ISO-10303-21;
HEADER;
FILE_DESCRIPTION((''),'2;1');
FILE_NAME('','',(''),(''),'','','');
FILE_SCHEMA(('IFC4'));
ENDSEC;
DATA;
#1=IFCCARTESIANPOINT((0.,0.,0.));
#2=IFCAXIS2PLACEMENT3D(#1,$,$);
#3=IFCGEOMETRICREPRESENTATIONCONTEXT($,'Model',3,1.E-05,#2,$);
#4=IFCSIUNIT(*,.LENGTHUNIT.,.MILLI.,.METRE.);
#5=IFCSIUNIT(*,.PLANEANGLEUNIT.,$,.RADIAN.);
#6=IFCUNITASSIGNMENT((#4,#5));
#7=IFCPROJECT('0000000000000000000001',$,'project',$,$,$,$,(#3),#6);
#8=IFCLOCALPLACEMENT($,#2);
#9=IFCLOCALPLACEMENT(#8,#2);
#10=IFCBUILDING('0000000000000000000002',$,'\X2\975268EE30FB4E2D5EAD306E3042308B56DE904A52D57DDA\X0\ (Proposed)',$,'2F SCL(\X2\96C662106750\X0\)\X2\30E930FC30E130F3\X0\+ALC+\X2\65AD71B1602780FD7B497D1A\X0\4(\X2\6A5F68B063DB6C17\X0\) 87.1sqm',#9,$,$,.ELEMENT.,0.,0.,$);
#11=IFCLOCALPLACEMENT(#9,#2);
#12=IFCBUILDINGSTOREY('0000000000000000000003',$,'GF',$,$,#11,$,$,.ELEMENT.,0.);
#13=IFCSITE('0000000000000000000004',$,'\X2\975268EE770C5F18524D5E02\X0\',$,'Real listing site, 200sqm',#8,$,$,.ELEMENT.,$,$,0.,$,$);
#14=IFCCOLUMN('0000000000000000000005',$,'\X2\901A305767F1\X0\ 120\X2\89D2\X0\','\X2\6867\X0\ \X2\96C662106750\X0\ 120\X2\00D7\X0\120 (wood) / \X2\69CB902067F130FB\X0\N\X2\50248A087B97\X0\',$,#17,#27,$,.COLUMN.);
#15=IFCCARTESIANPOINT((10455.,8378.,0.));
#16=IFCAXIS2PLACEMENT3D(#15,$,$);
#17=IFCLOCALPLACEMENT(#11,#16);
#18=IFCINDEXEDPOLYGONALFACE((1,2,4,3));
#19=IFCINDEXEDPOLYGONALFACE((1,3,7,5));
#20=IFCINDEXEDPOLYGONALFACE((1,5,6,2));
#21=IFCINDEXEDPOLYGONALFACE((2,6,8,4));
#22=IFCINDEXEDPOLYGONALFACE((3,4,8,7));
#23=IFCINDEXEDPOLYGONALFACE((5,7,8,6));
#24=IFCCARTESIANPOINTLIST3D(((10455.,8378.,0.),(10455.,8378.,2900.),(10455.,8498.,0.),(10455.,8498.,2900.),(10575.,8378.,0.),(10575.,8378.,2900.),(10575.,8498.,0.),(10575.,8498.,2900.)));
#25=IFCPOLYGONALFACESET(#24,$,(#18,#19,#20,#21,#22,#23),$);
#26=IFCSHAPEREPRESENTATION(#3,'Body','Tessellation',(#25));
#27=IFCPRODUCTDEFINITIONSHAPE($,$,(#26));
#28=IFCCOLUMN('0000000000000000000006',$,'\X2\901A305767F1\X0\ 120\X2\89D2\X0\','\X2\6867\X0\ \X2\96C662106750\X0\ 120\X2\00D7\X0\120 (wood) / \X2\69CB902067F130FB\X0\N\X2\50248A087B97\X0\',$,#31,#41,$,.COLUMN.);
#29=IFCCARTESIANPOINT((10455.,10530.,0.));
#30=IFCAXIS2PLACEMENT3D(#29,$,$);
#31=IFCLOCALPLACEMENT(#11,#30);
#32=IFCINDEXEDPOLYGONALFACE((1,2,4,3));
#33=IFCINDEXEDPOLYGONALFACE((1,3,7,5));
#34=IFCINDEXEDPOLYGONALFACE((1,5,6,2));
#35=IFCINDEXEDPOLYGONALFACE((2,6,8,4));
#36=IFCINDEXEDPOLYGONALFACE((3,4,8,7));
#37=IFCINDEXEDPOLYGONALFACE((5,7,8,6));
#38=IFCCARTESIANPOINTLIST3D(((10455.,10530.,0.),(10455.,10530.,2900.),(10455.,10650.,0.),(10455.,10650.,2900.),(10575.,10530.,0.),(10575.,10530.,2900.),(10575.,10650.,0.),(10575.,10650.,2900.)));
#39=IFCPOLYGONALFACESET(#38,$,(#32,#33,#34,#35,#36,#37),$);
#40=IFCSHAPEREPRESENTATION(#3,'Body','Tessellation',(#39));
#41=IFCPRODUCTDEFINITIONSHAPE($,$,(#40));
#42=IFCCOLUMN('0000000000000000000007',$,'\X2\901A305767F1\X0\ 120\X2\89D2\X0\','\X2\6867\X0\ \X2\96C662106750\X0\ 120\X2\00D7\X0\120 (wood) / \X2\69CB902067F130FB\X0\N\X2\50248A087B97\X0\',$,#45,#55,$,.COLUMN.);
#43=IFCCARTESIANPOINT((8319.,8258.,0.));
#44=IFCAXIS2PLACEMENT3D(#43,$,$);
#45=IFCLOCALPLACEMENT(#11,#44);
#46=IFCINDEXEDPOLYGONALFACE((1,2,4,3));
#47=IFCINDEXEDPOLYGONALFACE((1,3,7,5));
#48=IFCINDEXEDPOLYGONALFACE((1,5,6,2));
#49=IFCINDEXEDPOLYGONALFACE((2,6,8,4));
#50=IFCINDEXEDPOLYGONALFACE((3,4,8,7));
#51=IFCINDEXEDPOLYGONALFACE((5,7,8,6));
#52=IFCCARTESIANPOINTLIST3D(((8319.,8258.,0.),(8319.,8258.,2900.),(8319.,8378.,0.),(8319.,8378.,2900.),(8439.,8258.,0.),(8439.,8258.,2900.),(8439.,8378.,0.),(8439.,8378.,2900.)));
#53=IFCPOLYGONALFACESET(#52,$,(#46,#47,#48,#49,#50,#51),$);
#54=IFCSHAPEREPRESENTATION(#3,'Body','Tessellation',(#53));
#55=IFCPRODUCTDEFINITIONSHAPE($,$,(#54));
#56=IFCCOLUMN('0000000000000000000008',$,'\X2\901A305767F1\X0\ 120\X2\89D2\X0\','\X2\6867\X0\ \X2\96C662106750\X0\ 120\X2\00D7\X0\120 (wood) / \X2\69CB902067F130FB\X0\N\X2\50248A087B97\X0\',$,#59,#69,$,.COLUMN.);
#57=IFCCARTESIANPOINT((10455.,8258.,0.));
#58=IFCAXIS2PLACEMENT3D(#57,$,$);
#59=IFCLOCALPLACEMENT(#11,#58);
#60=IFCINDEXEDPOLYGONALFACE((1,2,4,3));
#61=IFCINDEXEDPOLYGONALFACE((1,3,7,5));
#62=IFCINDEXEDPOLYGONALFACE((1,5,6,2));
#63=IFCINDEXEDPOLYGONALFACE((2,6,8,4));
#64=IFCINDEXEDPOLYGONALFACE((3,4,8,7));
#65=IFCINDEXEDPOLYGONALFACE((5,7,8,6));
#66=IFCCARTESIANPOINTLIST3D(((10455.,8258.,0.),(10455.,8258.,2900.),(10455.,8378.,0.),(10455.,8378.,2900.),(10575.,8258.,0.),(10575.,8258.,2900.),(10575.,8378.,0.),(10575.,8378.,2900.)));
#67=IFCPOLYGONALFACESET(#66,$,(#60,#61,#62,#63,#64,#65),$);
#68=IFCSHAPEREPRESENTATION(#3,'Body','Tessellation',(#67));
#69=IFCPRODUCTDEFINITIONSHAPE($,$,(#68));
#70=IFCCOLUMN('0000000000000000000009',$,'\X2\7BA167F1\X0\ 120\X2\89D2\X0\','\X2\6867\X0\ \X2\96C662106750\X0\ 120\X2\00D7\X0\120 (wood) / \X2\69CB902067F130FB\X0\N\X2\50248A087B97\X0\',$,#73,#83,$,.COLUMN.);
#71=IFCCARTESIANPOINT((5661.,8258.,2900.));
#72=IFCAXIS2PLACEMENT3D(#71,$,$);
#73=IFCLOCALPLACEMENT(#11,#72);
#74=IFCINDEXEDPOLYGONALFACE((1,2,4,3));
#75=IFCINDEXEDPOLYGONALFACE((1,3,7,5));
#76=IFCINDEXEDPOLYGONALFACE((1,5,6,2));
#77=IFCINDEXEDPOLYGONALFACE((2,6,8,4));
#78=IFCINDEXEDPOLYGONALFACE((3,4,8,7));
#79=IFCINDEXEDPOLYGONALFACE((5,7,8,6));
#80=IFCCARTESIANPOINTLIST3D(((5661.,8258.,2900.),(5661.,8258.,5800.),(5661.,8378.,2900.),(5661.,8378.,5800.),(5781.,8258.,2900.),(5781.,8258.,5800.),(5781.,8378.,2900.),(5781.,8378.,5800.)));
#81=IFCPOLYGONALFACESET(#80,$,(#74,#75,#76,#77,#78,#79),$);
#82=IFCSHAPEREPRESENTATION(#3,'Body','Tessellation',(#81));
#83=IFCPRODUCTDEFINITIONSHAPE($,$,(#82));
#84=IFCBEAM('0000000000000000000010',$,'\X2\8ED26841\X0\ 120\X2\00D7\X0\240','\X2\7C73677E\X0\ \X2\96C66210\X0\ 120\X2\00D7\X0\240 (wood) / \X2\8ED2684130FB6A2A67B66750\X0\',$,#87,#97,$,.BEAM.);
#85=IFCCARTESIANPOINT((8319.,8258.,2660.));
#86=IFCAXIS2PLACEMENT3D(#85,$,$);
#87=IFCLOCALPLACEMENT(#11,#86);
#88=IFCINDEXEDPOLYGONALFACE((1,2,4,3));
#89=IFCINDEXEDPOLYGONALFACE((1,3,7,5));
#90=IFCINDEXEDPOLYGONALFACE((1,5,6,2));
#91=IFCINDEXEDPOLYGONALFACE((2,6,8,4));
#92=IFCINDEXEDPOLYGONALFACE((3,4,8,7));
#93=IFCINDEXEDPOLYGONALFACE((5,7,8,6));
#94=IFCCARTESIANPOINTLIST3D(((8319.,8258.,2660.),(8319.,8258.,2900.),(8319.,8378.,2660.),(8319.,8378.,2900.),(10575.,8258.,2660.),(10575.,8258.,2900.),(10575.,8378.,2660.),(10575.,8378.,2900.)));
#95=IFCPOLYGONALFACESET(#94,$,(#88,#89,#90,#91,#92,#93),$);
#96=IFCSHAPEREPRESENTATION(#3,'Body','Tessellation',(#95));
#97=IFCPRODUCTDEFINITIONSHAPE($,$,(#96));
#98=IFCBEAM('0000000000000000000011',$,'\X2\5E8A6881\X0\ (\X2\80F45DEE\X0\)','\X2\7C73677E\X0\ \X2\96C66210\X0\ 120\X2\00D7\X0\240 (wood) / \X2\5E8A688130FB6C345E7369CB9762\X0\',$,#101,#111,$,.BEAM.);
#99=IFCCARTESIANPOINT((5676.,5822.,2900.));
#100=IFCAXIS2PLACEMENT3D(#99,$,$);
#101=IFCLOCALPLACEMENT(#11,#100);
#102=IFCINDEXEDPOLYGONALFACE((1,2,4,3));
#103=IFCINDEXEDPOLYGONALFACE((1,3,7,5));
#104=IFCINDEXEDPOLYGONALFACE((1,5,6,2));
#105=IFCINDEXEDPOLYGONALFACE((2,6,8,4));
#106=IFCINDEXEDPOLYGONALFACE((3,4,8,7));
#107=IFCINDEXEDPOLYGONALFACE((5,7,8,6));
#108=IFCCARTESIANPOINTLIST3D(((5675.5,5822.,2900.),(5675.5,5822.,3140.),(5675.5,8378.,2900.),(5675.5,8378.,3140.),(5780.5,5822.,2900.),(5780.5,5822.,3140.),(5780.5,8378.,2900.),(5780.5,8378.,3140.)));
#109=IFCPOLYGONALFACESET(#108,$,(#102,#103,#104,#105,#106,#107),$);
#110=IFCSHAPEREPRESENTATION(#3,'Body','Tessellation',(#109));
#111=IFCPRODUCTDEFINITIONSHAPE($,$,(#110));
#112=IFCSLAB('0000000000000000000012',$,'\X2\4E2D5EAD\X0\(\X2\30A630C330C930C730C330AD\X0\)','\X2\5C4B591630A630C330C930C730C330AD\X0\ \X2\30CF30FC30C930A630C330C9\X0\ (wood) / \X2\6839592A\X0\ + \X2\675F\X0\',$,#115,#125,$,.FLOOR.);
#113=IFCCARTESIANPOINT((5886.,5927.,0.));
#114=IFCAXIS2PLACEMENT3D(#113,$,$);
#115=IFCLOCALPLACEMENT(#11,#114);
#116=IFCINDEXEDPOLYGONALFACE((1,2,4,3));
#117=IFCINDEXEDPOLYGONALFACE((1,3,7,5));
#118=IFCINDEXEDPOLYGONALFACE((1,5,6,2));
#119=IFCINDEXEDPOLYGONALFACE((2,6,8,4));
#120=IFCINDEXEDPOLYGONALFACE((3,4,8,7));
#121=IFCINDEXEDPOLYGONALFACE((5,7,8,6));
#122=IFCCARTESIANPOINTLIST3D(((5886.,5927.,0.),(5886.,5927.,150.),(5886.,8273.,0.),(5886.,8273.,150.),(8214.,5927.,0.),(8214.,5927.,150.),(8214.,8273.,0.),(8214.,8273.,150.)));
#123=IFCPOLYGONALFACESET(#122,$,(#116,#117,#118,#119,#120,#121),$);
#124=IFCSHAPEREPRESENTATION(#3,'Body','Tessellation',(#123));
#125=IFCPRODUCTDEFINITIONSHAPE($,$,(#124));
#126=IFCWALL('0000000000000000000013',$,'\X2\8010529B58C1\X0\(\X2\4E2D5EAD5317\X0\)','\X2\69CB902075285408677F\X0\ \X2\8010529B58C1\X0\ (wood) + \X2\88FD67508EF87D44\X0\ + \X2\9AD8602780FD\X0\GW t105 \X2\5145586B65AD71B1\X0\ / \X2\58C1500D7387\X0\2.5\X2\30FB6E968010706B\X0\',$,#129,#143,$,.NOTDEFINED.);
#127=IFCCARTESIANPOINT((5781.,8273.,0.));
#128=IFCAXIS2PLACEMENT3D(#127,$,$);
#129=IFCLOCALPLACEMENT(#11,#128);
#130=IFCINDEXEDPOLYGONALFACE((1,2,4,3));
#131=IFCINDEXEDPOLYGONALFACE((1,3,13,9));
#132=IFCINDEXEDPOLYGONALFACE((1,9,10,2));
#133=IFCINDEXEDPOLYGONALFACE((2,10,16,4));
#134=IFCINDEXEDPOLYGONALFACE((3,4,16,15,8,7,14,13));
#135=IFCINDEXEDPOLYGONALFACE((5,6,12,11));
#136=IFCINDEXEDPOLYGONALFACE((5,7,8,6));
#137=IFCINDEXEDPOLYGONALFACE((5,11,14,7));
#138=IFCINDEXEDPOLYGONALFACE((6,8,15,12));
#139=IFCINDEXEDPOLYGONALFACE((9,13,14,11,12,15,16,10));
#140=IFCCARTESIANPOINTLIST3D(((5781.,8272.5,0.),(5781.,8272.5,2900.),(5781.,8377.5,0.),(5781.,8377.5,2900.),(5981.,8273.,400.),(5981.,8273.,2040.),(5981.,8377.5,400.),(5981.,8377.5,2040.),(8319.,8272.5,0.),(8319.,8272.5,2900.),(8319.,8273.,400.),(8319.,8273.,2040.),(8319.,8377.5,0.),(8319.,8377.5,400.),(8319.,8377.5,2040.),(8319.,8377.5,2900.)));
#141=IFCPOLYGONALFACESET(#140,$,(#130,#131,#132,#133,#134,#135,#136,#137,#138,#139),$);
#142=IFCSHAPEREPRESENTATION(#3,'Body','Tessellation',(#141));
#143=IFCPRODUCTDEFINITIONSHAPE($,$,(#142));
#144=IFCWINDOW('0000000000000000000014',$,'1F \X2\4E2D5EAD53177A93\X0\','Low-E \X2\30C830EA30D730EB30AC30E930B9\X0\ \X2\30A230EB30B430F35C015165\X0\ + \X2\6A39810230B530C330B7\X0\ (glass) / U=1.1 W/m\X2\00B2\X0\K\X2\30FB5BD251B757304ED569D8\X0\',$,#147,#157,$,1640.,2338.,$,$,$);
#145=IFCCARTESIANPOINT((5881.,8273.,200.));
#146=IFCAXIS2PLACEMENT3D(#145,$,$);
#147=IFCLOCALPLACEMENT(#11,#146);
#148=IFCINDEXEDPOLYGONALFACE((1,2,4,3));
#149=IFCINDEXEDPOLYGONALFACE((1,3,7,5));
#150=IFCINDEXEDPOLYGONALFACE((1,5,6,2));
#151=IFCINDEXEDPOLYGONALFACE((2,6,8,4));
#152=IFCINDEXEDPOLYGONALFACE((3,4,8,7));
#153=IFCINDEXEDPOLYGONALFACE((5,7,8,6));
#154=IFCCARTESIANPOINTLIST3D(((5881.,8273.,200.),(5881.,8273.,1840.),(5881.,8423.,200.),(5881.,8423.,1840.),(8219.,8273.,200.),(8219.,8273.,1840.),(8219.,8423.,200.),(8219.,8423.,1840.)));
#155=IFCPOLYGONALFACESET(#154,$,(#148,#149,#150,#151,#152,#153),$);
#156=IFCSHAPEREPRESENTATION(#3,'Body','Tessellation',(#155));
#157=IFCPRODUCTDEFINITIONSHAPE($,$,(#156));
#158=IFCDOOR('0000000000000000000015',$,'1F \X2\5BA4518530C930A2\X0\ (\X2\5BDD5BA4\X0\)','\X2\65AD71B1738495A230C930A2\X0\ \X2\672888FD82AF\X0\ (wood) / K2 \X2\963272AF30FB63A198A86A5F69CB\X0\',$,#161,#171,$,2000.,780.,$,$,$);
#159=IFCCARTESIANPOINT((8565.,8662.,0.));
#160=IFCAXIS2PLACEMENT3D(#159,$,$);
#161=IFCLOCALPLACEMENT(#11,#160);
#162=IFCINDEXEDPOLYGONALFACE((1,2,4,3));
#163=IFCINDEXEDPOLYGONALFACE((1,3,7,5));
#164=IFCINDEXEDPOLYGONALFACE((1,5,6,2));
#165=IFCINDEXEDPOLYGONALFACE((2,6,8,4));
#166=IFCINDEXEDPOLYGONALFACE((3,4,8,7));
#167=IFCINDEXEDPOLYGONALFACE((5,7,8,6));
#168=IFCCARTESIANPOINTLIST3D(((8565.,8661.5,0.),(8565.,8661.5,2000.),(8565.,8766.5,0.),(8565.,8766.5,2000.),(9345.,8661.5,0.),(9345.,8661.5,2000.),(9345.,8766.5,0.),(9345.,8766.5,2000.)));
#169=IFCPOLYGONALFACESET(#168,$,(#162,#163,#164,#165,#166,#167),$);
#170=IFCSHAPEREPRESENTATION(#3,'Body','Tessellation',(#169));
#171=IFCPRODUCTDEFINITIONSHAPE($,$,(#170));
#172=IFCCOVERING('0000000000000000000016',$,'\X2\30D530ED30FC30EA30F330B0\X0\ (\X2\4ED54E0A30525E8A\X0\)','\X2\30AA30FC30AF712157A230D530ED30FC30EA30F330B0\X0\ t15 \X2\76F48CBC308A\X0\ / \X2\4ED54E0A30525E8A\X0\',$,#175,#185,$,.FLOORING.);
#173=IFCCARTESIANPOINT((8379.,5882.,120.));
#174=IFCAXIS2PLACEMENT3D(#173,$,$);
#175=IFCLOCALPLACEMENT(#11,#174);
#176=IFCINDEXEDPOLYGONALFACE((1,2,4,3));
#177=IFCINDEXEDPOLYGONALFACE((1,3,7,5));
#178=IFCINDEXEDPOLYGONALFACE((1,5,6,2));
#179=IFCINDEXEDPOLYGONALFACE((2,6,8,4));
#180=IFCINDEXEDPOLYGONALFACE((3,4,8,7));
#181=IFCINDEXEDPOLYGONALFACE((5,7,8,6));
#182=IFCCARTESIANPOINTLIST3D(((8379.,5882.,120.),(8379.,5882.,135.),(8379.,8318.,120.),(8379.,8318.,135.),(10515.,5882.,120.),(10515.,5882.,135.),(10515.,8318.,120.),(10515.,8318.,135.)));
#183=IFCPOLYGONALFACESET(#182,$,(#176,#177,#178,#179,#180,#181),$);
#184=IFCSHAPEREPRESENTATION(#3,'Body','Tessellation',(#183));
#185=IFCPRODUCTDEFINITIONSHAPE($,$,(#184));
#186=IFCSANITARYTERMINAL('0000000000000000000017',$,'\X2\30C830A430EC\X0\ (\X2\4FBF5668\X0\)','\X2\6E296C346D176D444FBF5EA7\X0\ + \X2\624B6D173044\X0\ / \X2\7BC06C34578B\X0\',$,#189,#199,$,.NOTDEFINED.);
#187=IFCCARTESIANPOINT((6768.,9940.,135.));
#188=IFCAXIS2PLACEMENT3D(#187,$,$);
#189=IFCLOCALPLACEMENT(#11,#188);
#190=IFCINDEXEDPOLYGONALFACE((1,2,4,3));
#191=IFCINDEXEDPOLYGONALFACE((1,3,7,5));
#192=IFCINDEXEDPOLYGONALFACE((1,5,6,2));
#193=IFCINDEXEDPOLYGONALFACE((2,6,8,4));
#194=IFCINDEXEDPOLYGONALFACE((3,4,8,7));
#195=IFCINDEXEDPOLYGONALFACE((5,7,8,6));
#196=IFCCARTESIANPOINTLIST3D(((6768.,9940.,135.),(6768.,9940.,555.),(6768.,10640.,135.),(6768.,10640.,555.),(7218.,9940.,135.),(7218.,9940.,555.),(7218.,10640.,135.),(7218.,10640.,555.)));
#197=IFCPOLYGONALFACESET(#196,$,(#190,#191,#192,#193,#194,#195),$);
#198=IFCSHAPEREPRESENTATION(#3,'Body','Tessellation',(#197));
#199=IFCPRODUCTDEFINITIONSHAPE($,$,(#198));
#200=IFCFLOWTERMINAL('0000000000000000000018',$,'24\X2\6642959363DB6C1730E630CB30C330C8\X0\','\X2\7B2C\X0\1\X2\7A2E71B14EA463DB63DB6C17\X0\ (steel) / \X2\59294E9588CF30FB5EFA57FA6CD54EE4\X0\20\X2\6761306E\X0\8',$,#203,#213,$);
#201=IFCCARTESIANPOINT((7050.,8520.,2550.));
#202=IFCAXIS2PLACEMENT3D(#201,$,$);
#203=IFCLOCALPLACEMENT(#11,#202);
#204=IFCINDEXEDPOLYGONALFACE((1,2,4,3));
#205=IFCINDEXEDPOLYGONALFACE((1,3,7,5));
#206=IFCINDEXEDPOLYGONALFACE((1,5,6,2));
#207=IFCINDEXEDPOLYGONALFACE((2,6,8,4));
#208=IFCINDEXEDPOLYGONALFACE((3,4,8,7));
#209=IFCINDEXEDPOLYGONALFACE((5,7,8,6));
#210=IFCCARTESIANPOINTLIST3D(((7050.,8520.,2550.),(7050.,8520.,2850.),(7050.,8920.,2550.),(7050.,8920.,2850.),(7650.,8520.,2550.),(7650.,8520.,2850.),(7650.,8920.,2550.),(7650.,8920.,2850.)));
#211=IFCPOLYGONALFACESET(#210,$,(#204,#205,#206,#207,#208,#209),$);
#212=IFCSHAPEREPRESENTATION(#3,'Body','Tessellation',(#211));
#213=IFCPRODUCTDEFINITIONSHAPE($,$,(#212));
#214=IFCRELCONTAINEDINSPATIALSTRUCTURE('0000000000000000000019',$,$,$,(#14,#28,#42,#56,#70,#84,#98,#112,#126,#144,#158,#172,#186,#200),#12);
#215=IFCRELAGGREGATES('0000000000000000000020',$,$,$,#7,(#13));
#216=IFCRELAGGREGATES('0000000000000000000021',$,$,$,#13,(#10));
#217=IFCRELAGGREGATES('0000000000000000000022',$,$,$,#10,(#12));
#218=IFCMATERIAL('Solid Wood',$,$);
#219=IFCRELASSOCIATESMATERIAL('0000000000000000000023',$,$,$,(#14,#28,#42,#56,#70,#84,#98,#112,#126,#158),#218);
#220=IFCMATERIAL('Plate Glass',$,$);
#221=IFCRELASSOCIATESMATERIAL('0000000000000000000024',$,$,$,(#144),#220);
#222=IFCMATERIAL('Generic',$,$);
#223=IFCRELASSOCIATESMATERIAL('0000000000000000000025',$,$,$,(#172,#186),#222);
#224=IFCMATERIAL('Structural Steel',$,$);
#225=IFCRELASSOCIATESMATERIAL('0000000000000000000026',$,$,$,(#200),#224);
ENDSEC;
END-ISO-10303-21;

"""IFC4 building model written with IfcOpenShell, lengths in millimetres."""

from ifc_helpers import new_model, si_unit, frame, frame_2d, origin, place, context, project, spatial, rectangle, extrude, material, element, fill, save


model = new_model("IFC4")

# Units and contexts
model_context = context("Model", 3, precision=1e-05, world=origin())
ifc_project = project(units=[si_unit("LENGTHUNIT", "METRE", prefix="MILLI"), si_unit("PLANEANGLEUNIT", "RADIAN")], contexts=[model_context])

# Site, building, storey
site_placement = place(None, origin())
site = spatial("IfcSite", under=ifc_project, at=site_placement, Name="青森県弘前市", ObjectType="Real listing site, 200sqm", CompositionType="ELEMENT", RefElevation=0.0)
building_placement = place(site_placement, origin())
building = spatial("IfcBuilding", under=site, at=building_placement, Name="青森・中庭のある回遊動線 (Proposed)", ObjectType="2F SCL(集成材)ラーメン+ALC+断熱性能等級4(機械換気) 87.1sqm", CompositionType="ELEMENT", ElevationOfRefHeight=0.0, ElevationOfTerrain=0.0)
storey_placement = place(building_placement, origin())
storey = spatial("IfcBuildingStorey", under=building, at=storey_placement, Name="GF", CompositionType="ELEMENT", Elevation=0.0)

# Columns
ifc_material_1 = material(Name="Solid Wood")
column_1_placement = place(storey_placement, frame((10455.0, 8378.0, 0.0)))
element("IfcColumn", 1, at=column_1_placement, inside=storey, material=ifc_material_1, Name="通し柱 120角", Description="桧 集成材 120×120 (wood) / 構造柱・N値計算", PredefinedType="COLUMN", context=model_context, shape_type="SweptSolid", body=[
    extrude(rectangle(XDim=120.0, YDim=120.0, at=frame_2d((60.0, 60.0))), frame((10455.0, 8378.0, 0.0)), (0.0, 0.0, 1.0), 2900.0),
])
column_2_placement = place(storey_placement, frame((10455.0, 10530.0, 0.0)))
element("IfcColumn", 2, at=column_2_placement, inside=storey, material=ifc_material_1, Name="通し柱 120角", Description="桧 集成材 120×120 (wood) / 構造柱・N値計算", PredefinedType="COLUMN", context=model_context, shape_type="SweptSolid", body=[
    extrude(rectangle(XDim=120.0, YDim=120.0, at=frame_2d((60.0, 60.0))), frame((10455.0, 10530.0, 0.0)), (0.0, 0.0, 1.0), 2900.0),
])
column_3_placement = place(storey_placement, frame((8319.0, 8258.0, 0.0)))
element("IfcColumn", 3, at=column_3_placement, inside=storey, material=ifc_material_1, Name="通し柱 120角", Description="桧 集成材 120×120 (wood) / 構造柱・N値計算", PredefinedType="COLUMN", context=model_context, shape_type="SweptSolid", body=[
    extrude(rectangle(XDim=120.0, YDim=120.0, at=frame_2d((60.0, 60.0))), frame((8319.0, 8258.0, 0.0)), (0.0, 0.0, 1.0), 2900.0),
])
column_4_placement = place(storey_placement, frame((10455.0, 8258.0, 0.0)))
element("IfcColumn", 4, at=column_4_placement, inside=storey, material=ifc_material_1, Name="通し柱 120角", Description="桧 集成材 120×120 (wood) / 構造柱・N値計算", PredefinedType="COLUMN", context=model_context, shape_type="SweptSolid", body=[
    extrude(rectangle(XDim=120.0, YDim=120.0, at=frame_2d((60.0, 60.0))), frame((10455.0, 8258.0, 0.0)), (0.0, 0.0, 1.0), 2900.0),
])
column_5_placement = place(storey_placement, frame((5661.0, 8258.0, 2900.0)))
element("IfcColumn", 5, at=column_5_placement, inside=storey, material=ifc_material_1, Name="管柱 120角", Description="桧 集成材 120×120 (wood) / 構造柱・N値計算", PredefinedType="COLUMN", context=model_context, shape_type="SweptSolid", body=[
    extrude(rectangle(XDim=120.0, YDim=120.0, at=frame_2d((60.0, 60.0))), frame((5661.0, 8258.0, 2900.0)), (0.0, 0.0, 1.0), 2900.0),
])

# Beams
beam_1_placement = place(storey_placement, frame((8319.0, 8258.0, 2660.0)))
element("IfcBeam", 6, at=beam_1_placement, inside=storey, material=ifc_material_1, Name="軒桁 120×240", Description="米松 集成 120×240 (wood) / 軒桁・横架材", PredefinedType="BEAM", context=model_context, shape_type="SweptSolid", body=[
    extrude(rectangle(XDim=2256.0, YDim=120.0, at=frame_2d((1128.0, 60.0))), frame((8319.0, 8258.0, 2660.0)), (0.0, 0.0, 1.0), 240.0),
])
beam_2_placement = place(storey_placement, frame((5676.0, 5822.0, 2900.0)))
element("IfcBeam", 7, at=beam_2_placement, inside=storey, material=ifc_material_1, Name="床梁 (胴差)", Description="米松 集成 120×240 (wood) / 床梁・水平構面", PredefinedType="BEAM", context=model_context, shape_type="SweptSolid", body=[
    extrude(rectangle(XDim=105.0, YDim=2556.0, at=frame_2d((52.0, 1278.0))), frame((5676.0, 5822.0, 2900.0)), (0.0, 0.0, 1.0), 240.0),
])

# Slab
slab_placement = place(storey_placement, frame((5886.0, 5927.0, 0.0)))
element("IfcSlab", 8, at=slab_placement, inside=storey, material=ifc_material_1, Name="中庭(ウッドデッキ)", Description="屋外ウッドデッキ ハードウッド (wood) / 根太 + 束", PredefinedType="FLOOR", context=model_context, shape_type="SweptSolid", body=[
    extrude(rectangle(XDim=2328.0, YDim=2346.0, at=frame_2d((1164.0, 1173.0))), frame((5886.0, 5927.0, 0.0)), (0.0, 0.0, 1.0), 150.0),
])

# Wall, opening, window
wall_1_placement = place(storey_placement, frame((5781.0, 8273.0, 0.0)))
wall_1 = element("IfcWall", 9, at=wall_1_placement, inside=storey, material=ifc_material_1, Name="耐力壁(中庭北)", Description="構造用合板 耐力壁 (wood) + 製材軸組 + 高性能GW t105 充填断熱 / 壁倍率2.5・準耐火", PredefinedType="NOTDEFINED", context=model_context, shape_type="SweptSolid", body=[
    extrude(rectangle(XDim=2538.0, YDim=105.0, at=frame_2d((1269.0, 52.0))), frame((5781.0, 8273.0, 0.0)), (0.0, 0.0, 1.0), 2900.0),
])
opening_placement = place(storey_placement, frame((5881.0, 8273.0, 200.0)))
opening = element("IfcOpeningElement", 10, at=opening_placement, cuts=wall_1, PredefinedType="NOTDEFINED", context=model_context, shape_type="SweptSolid", body=[
    extrude(rectangle(XDim=2338.0, YDim=150.0, at=frame_2d((1169.0, 75.0))), frame((5881.0, 8273.0, 200.0)), (0.0, 0.0, 1.0), 1640.0),
])
ifc_material_2 = material(Name="Plate Glass")
window_placement = place(storey_placement, frame((5881.0, 8273.0, 200.0)))
window = element("IfcWindow", 11, at=window_placement, inside=storey, material=ifc_material_2, Name="1F 中庭北窓", Description="Low-E トリプルガラス アルゴン封入 + 樹脂サッシ (glass) / U=1.1 W/m²K・寒冷地仕様", OverallHeight=1640.0, OverallWidth=2338.0, context=model_context, shape_type="SweptSolid", body=[
    extrude(rectangle(XDim=2338.0, YDim=150.0, at=frame_2d((1169.0, 75.0))), frame((5881.0, 8273.0, 200.0)), (0.0, 0.0, 1.0), 1640.0),
])
fill(opening, window)

# Door
door_placement = place(storey_placement, frame((8565.0, 8662.0, 0.0)))
element("IfcDoor", 12, at=door_placement, inside=storey, material=ifc_material_1, Name="1F 室内ドア (寝室)", Description="断熱玄関ドア 木製芯 (wood) / K2 防犯・採風機構", OverallHeight=2000.0, OverallWidth=780.0, context=model_context, shape_type="SweptSolid", body=[
    extrude(rectangle(XDim=780.0, YDim=105.0, at=frame_2d((390.0, 52.0))), frame((8565.0, 8662.0, 0.0)), (0.0, 0.0, 1.0), 2000.0),
])

# Covering
ifc_material_3 = material(Name="Generic")
covering_placement = place(storey_placement, frame((8379.0, 5882.0, 120.0)))
element("IfcCovering", 13, at=covering_placement, inside=storey, material=ifc_material_3, Name="フローリング (仕上げ床)", Description="オーク無垢フローリング t15 直貼り / 仕上げ床", PredefinedType="FLOORING", context=model_context, shape_type="SweptSolid", body=[
    extrude(rectangle(XDim=2136.0, YDim=2436.0, at=frame_2d((1068.0, 1218.0))), frame((8379.0, 5882.0, 120.0)), (0.0, 0.0, 1.0), 15.0),
])

# Sanitary terminal
sanitary_terminal_placement = place(storey_placement, frame((6768.0, 9940.0, 135.0)))
element("IfcSanitaryTerminal", 14, at=sanitary_terminal_placement, inside=storey, material=ifc_material_3, Name="トイレ (便器)", Description="温水洗浄便座 + 手洗い / 節水型", PredefinedType="NOTDEFINED", context=model_context, shape_type="SweptSolid", body=[
    extrude(rectangle(XDim=450.0, YDim=700.0, at=frame_2d((225.0, 350.0))), frame((6768.0, 9940.0, 135.0)), (0.0, 0.0, 1.0), 420.0),
])

# Flow terminal
ifc_material_4 = material(Name="Structural Steel")
flow_terminal_placement = place(storey_placement, frame((7050.0, 8520.0, 2550.0)))
element("IfcFlowTerminal", 15, at=flow_terminal_placement, inside=storey, material=ifc_material_4, Name="24時間換気ユニット", Description="第1種熱交換換気 (steel) / 天井裏・建基法令20条の8", context=model_context, shape_type="SweptSolid", body=[
    extrude(rectangle(XDim=600.0, YDim=400.0, at=frame_2d((300.0, 200.0))), frame((7050.0, 8520.0, 2550.0)), (0.0, 0.0, 1.0), 300.0),
])

save(model, "model.ifc")
